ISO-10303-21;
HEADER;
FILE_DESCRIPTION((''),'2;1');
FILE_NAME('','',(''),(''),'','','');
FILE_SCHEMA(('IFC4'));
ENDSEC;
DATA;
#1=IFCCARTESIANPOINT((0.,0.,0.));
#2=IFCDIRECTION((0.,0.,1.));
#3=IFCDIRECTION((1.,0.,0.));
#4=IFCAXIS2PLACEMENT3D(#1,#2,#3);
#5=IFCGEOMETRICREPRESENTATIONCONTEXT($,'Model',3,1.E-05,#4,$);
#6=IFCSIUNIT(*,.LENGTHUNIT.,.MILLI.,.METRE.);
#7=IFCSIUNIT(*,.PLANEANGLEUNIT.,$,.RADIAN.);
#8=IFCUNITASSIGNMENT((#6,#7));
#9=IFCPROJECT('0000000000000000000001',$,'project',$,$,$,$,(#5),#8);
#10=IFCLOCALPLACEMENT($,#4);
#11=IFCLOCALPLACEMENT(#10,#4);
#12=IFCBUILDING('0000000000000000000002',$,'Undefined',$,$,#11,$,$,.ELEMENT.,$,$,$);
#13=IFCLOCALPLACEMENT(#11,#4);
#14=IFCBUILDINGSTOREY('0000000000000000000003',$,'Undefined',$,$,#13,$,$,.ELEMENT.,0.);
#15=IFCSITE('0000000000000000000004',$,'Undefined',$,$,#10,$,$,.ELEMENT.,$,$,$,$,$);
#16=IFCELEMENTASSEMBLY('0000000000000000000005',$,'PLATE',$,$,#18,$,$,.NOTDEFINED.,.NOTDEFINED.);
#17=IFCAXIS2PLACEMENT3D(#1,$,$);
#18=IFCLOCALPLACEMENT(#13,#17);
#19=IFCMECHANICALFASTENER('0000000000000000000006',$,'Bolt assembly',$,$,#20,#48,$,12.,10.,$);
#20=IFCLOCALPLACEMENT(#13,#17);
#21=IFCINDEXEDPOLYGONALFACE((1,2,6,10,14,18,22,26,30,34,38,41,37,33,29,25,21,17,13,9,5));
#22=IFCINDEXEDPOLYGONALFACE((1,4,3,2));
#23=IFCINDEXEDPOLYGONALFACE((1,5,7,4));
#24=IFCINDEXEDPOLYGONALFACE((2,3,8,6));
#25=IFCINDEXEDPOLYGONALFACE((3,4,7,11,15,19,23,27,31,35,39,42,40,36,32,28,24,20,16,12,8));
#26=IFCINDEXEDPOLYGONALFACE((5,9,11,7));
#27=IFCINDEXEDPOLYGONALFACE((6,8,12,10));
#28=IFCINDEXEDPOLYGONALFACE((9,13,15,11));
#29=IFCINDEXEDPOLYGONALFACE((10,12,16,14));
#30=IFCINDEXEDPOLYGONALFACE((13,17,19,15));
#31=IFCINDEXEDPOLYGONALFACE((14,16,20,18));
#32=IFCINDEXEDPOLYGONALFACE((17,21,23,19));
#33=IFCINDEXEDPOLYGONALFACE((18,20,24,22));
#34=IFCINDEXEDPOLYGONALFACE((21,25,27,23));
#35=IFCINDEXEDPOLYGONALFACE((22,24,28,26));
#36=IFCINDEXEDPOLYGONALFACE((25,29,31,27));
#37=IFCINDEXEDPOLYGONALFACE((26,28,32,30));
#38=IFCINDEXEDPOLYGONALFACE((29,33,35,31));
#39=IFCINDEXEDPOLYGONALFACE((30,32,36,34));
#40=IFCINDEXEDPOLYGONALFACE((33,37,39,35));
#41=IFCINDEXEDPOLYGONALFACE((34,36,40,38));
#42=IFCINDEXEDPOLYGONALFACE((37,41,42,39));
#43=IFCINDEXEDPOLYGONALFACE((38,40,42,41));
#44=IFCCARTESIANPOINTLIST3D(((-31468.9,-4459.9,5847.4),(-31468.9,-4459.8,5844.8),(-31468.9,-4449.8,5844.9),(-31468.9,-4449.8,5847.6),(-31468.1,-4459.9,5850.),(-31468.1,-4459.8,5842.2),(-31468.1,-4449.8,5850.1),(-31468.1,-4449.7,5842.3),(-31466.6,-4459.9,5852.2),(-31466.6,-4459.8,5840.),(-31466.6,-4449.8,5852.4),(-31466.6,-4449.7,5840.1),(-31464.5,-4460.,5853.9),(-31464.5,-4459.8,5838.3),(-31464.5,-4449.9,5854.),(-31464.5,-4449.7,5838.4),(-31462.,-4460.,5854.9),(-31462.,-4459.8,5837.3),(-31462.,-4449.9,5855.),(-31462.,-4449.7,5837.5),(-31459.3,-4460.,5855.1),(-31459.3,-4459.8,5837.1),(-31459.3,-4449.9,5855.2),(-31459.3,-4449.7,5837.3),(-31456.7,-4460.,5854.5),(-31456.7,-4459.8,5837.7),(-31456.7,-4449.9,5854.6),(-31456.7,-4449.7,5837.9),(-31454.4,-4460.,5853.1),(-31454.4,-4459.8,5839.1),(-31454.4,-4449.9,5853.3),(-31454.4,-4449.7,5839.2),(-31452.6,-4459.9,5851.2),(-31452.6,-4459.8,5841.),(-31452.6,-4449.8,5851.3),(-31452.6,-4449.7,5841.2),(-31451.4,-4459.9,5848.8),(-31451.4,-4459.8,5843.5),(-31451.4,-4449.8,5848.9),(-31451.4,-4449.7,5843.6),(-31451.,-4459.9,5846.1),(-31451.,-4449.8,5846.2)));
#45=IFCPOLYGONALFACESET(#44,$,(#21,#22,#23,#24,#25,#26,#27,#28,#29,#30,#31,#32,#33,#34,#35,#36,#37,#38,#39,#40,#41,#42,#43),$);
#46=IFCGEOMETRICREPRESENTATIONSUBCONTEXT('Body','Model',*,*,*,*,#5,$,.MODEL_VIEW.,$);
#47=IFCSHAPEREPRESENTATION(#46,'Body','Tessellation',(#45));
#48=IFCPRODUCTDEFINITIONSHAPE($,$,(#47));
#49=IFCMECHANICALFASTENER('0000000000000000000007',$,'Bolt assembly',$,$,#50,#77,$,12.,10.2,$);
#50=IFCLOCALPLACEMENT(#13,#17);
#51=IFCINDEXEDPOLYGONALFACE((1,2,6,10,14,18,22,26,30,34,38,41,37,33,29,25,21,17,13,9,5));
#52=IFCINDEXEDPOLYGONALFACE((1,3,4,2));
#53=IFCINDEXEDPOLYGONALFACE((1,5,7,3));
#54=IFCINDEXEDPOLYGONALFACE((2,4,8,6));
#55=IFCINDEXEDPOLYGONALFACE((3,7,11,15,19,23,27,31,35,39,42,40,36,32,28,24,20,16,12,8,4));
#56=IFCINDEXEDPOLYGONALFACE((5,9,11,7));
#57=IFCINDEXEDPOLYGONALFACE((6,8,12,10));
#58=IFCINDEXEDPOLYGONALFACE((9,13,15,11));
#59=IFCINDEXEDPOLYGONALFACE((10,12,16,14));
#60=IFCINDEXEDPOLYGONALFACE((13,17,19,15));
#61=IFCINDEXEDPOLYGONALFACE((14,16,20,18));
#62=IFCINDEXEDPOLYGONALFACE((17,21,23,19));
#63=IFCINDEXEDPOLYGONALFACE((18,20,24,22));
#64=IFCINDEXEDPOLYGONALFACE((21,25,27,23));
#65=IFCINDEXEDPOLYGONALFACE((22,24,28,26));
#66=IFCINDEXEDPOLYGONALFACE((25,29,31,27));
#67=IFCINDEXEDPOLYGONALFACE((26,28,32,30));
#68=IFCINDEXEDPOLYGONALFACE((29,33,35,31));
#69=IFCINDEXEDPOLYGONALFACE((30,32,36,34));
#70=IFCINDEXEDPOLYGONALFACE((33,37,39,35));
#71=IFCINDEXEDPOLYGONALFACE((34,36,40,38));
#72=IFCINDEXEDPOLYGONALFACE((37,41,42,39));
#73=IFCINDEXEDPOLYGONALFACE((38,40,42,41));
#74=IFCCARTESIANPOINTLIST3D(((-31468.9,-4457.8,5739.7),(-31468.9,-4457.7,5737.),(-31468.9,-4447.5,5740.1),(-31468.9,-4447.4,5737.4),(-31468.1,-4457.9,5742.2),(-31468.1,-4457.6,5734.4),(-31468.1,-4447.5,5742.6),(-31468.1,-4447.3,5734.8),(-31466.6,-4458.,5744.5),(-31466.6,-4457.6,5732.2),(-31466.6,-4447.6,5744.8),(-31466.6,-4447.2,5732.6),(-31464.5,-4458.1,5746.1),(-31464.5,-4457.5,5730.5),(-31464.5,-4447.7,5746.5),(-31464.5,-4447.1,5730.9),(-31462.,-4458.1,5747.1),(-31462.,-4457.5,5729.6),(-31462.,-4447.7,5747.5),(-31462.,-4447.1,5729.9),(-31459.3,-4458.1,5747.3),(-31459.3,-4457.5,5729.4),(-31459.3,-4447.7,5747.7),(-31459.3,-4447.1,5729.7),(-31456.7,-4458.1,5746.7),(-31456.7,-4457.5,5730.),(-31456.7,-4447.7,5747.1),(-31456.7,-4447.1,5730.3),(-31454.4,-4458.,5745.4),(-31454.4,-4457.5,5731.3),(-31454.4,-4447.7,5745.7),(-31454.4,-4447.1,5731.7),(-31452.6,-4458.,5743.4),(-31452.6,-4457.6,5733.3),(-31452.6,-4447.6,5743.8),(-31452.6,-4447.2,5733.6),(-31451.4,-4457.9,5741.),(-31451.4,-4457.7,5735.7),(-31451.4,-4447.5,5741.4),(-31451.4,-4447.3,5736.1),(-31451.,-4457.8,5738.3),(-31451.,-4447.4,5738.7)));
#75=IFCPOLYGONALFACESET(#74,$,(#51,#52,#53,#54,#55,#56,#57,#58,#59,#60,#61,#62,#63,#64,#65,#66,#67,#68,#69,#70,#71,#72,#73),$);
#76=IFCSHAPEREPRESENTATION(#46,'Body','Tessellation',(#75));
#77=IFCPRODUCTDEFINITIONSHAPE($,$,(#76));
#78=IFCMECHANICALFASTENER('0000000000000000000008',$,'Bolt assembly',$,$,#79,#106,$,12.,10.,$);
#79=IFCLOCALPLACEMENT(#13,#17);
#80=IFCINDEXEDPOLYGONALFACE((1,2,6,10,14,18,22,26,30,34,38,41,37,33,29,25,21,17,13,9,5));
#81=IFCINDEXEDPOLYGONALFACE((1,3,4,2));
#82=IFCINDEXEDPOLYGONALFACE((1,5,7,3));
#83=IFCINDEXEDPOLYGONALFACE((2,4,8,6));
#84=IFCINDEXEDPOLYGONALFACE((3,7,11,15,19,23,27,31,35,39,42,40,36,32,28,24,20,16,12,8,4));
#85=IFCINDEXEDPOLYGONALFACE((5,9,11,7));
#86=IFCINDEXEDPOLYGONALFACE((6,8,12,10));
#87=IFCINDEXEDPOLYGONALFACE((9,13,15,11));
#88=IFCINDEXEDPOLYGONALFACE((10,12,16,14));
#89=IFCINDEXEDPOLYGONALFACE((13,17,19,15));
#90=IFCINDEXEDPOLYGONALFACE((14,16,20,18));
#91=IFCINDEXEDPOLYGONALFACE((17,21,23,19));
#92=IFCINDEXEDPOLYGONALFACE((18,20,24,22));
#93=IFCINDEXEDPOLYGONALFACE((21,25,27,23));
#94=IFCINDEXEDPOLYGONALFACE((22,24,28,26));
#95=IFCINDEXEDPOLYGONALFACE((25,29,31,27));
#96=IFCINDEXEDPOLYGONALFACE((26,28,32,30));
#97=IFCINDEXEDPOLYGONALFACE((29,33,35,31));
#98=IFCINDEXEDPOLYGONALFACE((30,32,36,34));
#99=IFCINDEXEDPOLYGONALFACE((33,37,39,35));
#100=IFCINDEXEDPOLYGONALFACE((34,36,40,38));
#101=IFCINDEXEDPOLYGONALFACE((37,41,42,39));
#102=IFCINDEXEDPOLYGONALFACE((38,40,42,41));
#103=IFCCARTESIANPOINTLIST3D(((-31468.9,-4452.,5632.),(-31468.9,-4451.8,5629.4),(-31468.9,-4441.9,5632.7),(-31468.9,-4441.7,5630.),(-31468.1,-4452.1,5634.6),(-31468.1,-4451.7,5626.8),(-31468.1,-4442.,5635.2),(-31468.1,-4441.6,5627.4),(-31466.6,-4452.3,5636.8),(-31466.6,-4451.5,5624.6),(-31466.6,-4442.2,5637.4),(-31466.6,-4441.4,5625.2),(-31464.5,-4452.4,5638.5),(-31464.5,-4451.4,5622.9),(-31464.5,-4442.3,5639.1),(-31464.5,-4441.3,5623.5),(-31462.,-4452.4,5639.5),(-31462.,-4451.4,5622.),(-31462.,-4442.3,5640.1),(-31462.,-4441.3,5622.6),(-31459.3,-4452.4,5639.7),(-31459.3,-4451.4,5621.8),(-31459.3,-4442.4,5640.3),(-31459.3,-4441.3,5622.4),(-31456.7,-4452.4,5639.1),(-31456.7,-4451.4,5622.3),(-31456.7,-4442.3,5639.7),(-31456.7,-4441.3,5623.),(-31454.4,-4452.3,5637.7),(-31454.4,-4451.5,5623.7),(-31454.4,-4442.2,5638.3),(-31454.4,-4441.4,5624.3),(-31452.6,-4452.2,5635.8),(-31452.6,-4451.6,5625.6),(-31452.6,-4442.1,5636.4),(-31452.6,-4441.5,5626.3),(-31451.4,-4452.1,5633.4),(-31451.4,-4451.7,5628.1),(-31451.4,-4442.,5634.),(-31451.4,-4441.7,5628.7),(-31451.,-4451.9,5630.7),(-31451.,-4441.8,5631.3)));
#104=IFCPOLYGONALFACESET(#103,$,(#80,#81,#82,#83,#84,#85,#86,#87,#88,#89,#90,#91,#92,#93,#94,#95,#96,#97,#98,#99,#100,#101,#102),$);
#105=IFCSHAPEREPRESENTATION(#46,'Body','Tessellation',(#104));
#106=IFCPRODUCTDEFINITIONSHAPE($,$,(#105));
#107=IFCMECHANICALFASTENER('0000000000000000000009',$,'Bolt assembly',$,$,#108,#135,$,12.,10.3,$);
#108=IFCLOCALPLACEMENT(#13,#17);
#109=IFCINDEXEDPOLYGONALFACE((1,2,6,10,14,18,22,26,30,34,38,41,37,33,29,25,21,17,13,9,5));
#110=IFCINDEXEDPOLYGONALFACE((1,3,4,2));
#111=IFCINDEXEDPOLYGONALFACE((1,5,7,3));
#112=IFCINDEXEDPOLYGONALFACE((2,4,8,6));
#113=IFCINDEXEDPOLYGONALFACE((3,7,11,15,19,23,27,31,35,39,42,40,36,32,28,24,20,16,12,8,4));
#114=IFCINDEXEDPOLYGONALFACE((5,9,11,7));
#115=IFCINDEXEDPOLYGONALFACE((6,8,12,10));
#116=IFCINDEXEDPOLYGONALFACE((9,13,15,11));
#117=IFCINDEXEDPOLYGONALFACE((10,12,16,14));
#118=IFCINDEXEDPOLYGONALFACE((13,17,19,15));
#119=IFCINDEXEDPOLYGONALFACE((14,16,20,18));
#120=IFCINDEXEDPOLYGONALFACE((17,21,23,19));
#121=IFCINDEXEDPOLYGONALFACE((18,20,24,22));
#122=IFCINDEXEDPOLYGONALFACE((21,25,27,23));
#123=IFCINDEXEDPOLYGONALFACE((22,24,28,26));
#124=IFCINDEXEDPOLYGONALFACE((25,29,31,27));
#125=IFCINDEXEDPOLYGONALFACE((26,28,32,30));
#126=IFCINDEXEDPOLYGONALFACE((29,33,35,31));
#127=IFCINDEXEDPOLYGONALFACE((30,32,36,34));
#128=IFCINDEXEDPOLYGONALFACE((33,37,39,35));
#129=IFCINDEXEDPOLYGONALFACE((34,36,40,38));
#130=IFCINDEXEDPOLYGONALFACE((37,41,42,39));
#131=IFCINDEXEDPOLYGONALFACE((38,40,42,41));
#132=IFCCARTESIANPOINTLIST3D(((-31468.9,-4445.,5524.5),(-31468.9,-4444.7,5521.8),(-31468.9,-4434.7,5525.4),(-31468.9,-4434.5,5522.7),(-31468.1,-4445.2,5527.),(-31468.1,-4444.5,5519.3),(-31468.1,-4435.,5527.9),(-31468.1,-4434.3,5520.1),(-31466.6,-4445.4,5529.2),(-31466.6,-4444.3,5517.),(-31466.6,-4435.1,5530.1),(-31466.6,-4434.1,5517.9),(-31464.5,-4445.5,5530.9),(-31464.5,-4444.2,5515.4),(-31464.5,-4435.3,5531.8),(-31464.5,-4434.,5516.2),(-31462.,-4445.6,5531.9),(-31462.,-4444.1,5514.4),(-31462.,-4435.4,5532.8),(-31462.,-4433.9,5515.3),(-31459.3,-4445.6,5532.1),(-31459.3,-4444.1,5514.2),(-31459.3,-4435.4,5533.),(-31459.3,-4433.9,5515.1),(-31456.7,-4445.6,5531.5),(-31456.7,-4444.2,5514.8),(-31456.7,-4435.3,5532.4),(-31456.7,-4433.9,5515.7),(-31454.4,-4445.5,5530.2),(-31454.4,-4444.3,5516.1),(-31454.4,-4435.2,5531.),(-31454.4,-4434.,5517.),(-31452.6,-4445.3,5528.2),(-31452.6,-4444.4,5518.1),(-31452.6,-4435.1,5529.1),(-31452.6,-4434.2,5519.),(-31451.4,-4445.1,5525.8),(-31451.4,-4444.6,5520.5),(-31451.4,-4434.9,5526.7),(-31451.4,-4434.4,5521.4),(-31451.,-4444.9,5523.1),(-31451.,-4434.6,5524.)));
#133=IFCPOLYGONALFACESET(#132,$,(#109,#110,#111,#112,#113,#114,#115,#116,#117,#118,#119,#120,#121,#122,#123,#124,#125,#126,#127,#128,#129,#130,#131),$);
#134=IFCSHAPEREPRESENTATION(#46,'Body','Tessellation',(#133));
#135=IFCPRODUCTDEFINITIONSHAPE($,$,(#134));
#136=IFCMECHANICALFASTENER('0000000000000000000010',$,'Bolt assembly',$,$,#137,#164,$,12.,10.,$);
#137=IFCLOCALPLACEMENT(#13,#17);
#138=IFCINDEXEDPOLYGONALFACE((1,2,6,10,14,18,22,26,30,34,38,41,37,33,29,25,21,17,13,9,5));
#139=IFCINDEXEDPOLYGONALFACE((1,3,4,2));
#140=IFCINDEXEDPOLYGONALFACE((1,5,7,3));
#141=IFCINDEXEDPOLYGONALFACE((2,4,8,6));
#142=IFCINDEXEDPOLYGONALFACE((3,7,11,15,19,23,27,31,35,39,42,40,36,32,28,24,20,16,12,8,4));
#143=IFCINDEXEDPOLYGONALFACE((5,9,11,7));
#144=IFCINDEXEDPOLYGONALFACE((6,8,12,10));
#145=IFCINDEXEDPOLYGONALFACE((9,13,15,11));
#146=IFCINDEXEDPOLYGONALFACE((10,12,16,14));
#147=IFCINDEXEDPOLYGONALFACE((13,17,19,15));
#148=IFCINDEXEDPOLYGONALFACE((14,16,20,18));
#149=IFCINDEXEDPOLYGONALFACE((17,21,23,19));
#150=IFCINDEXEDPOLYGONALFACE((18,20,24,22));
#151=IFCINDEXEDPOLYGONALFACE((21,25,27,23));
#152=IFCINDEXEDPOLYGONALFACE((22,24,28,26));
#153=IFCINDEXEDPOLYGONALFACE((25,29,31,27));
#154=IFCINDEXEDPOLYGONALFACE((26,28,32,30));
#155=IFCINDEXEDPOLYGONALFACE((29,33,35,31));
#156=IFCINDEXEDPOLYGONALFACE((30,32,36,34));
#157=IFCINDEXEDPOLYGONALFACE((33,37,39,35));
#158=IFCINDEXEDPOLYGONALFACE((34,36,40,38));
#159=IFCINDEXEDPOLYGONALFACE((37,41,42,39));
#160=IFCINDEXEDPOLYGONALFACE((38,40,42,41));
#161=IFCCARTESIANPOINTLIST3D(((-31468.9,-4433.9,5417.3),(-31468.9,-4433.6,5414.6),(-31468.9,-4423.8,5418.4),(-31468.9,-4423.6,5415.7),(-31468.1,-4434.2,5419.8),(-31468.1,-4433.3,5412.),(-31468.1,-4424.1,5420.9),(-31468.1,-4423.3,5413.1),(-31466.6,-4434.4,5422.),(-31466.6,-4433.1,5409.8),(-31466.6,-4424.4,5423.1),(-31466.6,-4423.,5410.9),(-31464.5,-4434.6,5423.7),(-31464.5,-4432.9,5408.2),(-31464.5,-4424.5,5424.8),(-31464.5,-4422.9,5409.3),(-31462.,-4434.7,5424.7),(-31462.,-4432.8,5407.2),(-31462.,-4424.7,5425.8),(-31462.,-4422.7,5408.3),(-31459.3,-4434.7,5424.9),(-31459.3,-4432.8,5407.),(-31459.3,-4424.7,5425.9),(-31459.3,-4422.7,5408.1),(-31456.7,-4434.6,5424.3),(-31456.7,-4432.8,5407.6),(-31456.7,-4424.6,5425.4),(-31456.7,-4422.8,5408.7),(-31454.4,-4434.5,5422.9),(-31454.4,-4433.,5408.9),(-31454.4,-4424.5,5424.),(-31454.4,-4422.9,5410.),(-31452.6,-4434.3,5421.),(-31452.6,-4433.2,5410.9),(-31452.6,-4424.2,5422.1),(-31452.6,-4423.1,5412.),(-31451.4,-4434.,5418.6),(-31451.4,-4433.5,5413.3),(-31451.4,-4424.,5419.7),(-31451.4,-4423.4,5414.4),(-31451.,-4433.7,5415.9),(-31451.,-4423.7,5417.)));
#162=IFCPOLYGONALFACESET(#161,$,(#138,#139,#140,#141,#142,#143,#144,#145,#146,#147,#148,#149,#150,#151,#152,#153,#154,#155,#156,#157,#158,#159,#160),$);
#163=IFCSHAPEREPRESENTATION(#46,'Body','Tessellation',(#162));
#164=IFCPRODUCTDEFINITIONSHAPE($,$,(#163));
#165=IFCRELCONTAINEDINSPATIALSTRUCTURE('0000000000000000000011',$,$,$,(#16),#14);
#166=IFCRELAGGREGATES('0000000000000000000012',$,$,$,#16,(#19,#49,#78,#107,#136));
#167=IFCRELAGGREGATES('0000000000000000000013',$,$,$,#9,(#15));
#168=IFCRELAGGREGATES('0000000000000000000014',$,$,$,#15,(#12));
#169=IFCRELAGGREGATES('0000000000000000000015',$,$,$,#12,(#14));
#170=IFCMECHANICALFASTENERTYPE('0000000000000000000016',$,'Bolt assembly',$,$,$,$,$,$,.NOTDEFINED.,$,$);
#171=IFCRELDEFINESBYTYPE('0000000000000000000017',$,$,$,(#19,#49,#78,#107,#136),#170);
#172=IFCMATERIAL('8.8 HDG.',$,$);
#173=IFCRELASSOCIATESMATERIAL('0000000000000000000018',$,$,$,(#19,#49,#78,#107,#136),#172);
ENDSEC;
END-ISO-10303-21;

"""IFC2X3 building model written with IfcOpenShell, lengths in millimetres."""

from ifc_helpers import new_model, si_unit, frame, origin_with_axes, origin_2d_with_axis, place, context, subcontext, project, spatial, circle, extrude, source, transform, mapped, material, type_object, element, aggregate, save


model = new_model("IFC2X3")

# Units and contexts
model_context = context("Model", 3, precision=1e-05, world=origin_with_axes())
body_context = subcontext(model_context, "Body", "Model", "MODEL_VIEW")
ifc_project = project(units=[si_unit("LENGTHUNIT", "METRE", prefix="MILLI"), si_unit("PLANEANGLEUNIT", "RADIAN")], contexts=[model_context])

# Site, building, storey
site_placement = place(None, origin_with_axes())
site = spatial("IfcSite", under=ifc_project, at=site_placement, Name="Undefined", CompositionType="ELEMENT")
building_placement = place(site_placement, origin_with_axes())
building = spatial("IfcBuilding", under=site, at=building_placement, Name="Undefined", CompositionType="ELEMENT")
storey_placement = place(building_placement, origin_with_axes())
storey = spatial("IfcBuildingStorey", under=building, at=storey_placement, Name="Undefined", CompositionType="ELEMENT", Elevation=0.0)

# Element assembly
assembly_1_placement = place(storey_placement, origin_with_axes())
assembly_1 = element("IfcElementAssembly", 1, at=assembly_1_placement, inside=storey, Name="PLATE", AssemblyPlace="NOTDEFINED", PredefinedType="NOTDEFINED")

# Shared definitions
mechanical_fastener_type = type_object("IfcMechanicalFastenerType", Name="Bolt assembly")

# Mechanical fasteners
ifc_material_1 = material(Name="8.8 HDG.")
shared_shape_1 = source(origin_with_axes(), body_context, "Body", "SweptSolid", [
    extrude(circle(Radius=9.0, at=origin_2d_with_axis()), frame((0.0, 0.8, 0.0), z_axis=(0.0, 1.0, 0.0), x_axis=(1.0, 0.0, 0.0)), (0.0, 0.0, 1.0), 10.1),
])
mechanical_fastener_1_placement = place(assembly_1_placement, frame((-31460.0, -4460.6, 5846.1), z_axis=(0.000001, -0.012083, 0.999927), x_axis=(1.0, 0.0, -0.000001)))
mechanical_fastener_1 = element("IfcMechanicalFastener", 2, at=mechanical_fastener_1_placement, type_object=mechanical_fastener_type, material=ifc_material_1, Name="Bolt assembly", NominalDiameter=12.0, NominalLength=10.0, context=body_context, shape_type="MappedRepresentation", body=[
    mapped(shared_shape_1, transform((0.0, 0.0, 0.0))),
])
shared_shape_2 = source(origin_with_axes(), body_context, "Body", "SweptSolid", [
    extrude(circle(Radius=9.0, at=origin_2d_with_axis()), frame((0.0, 0.2, 0.0), z_axis=(0.0, 1.0, 0.0), x_axis=(1.0, 0.0, 0.0)), (0.0, 0.0, 1.0), 10.4),
])
mechanical_fastener_2_placement = place(assembly_1_placement, frame((-31460.0, -4458.0, 5738.3), z_axis=(0.000001, -0.036241, 0.999343), x_axis=(1.0, 0.0, -0.000001)))
mechanical_fastener_2 = element("IfcMechanicalFastener", 3, at=mechanical_fastener_2_placement, type_object=mechanical_fastener_type, material=ifc_material_1, Name="Bolt assembly", NominalDiameter=12.0, NominalLength=10.2, context=body_context, shape_type="MappedRepresentation", body=[
    mapped(shared_shape_2, transform((0.0, 0.0, 0.0))),
])
shared_shape_3 = source(origin_with_axes(), body_context, "Body", "SweptSolid", [
    extrude(circle(Radius=9.0, at=origin_2d_with_axis()), frame((0.0, 0.9, 0.0), z_axis=(0.0, 1.0, 0.0), x_axis=(1.0, 0.0, 0.0)), (0.0, 0.0, 1.0), 10.1),
])
mechanical_fastener_3_placement = place(assembly_1_placement, frame((-31460.0, -4452.8, 5630.7), z_axis=(0.000001, -0.060379, 0.998176), x_axis=(1.0, 0.0, -0.000001)))
mechanical_fastener_3 = element("IfcMechanicalFastener", 4, at=mechanical_fastener_3_placement, type_object=mechanical_fastener_type, material=ifc_material_1, Name="Bolt assembly", NominalDiameter=12.0, NominalLength=10.0, context=body_context, shape_type="MappedRepresentation", body=[
    mapped(shared_shape_3, transform((0.0, 0.0, 0.0))),
])
shared_shape_4 = source(origin_with_axes(), body_context, "Body", "SweptSolid", [
    extrude(circle(Radius=9.0, at=origin_2d_with_axis()), frame((0.0, 0.1, 0.0), z_axis=(0.0, 1.0, 0.0), x_axis=(1.0, 0.0, 0.0)), (0.0, 0.0, 1.0), 10.3),
])
mechanical_fastener_4_placement = place(assembly_1_placement, frame((-31460.0, -4445.0, 5523.1), z_axis=(0.000001, -0.084481, 0.996425), x_axis=(1.0, 0.0, -0.000001)))
mechanical_fastener_4 = element("IfcMechanicalFastener", 5, at=mechanical_fastener_4_placement, type_object=mechanical_fastener_type, material=ifc_material_1, Name="Bolt assembly", NominalDiameter=12.0, NominalLength=10.3, context=body_context, shape_type="MappedRepresentation", body=[
    mapped(shared_shape_4, transform((0.0, 0.0, 0.0))),
])
shared_shape_5 = source(origin_with_axes(), body_context, "Body", "SweptSolid", [
    extrude(circle(Radius=9.0, at=origin_2d_with_axis()), frame((0.0, 0.9, 0.0), z_axis=(0.0, 1.0, 0.0), x_axis=(1.0, 0.0, 0.0)), (0.0, 0.0, 1.0), 10.1),
])
mechanical_fastener_5_placement = place(assembly_1_placement, frame((-31460.0, -4434.6, 5415.8), z_axis=(0.000001, -0.108533, 0.994093), x_axis=(1.0, 0.0, -0.000001)))
mechanical_fastener_5 = element("IfcMechanicalFastener", 6, at=mechanical_fastener_5_placement, type_object=mechanical_fastener_type, material=ifc_material_1, Name="Bolt assembly", NominalDiameter=12.0, NominalLength=10.0, context=body_context, shape_type="MappedRepresentation", body=[
    mapped(shared_shape_5, transform((0.0, 0.0, 0.0))),
])
aggregate(assembly_1, [mechanical_fastener_1, mechanical_fastener_2, mechanical_fastener_3, mechanical_fastener_4, mechanical_fastener_5])

save(model, "model.ifc")
